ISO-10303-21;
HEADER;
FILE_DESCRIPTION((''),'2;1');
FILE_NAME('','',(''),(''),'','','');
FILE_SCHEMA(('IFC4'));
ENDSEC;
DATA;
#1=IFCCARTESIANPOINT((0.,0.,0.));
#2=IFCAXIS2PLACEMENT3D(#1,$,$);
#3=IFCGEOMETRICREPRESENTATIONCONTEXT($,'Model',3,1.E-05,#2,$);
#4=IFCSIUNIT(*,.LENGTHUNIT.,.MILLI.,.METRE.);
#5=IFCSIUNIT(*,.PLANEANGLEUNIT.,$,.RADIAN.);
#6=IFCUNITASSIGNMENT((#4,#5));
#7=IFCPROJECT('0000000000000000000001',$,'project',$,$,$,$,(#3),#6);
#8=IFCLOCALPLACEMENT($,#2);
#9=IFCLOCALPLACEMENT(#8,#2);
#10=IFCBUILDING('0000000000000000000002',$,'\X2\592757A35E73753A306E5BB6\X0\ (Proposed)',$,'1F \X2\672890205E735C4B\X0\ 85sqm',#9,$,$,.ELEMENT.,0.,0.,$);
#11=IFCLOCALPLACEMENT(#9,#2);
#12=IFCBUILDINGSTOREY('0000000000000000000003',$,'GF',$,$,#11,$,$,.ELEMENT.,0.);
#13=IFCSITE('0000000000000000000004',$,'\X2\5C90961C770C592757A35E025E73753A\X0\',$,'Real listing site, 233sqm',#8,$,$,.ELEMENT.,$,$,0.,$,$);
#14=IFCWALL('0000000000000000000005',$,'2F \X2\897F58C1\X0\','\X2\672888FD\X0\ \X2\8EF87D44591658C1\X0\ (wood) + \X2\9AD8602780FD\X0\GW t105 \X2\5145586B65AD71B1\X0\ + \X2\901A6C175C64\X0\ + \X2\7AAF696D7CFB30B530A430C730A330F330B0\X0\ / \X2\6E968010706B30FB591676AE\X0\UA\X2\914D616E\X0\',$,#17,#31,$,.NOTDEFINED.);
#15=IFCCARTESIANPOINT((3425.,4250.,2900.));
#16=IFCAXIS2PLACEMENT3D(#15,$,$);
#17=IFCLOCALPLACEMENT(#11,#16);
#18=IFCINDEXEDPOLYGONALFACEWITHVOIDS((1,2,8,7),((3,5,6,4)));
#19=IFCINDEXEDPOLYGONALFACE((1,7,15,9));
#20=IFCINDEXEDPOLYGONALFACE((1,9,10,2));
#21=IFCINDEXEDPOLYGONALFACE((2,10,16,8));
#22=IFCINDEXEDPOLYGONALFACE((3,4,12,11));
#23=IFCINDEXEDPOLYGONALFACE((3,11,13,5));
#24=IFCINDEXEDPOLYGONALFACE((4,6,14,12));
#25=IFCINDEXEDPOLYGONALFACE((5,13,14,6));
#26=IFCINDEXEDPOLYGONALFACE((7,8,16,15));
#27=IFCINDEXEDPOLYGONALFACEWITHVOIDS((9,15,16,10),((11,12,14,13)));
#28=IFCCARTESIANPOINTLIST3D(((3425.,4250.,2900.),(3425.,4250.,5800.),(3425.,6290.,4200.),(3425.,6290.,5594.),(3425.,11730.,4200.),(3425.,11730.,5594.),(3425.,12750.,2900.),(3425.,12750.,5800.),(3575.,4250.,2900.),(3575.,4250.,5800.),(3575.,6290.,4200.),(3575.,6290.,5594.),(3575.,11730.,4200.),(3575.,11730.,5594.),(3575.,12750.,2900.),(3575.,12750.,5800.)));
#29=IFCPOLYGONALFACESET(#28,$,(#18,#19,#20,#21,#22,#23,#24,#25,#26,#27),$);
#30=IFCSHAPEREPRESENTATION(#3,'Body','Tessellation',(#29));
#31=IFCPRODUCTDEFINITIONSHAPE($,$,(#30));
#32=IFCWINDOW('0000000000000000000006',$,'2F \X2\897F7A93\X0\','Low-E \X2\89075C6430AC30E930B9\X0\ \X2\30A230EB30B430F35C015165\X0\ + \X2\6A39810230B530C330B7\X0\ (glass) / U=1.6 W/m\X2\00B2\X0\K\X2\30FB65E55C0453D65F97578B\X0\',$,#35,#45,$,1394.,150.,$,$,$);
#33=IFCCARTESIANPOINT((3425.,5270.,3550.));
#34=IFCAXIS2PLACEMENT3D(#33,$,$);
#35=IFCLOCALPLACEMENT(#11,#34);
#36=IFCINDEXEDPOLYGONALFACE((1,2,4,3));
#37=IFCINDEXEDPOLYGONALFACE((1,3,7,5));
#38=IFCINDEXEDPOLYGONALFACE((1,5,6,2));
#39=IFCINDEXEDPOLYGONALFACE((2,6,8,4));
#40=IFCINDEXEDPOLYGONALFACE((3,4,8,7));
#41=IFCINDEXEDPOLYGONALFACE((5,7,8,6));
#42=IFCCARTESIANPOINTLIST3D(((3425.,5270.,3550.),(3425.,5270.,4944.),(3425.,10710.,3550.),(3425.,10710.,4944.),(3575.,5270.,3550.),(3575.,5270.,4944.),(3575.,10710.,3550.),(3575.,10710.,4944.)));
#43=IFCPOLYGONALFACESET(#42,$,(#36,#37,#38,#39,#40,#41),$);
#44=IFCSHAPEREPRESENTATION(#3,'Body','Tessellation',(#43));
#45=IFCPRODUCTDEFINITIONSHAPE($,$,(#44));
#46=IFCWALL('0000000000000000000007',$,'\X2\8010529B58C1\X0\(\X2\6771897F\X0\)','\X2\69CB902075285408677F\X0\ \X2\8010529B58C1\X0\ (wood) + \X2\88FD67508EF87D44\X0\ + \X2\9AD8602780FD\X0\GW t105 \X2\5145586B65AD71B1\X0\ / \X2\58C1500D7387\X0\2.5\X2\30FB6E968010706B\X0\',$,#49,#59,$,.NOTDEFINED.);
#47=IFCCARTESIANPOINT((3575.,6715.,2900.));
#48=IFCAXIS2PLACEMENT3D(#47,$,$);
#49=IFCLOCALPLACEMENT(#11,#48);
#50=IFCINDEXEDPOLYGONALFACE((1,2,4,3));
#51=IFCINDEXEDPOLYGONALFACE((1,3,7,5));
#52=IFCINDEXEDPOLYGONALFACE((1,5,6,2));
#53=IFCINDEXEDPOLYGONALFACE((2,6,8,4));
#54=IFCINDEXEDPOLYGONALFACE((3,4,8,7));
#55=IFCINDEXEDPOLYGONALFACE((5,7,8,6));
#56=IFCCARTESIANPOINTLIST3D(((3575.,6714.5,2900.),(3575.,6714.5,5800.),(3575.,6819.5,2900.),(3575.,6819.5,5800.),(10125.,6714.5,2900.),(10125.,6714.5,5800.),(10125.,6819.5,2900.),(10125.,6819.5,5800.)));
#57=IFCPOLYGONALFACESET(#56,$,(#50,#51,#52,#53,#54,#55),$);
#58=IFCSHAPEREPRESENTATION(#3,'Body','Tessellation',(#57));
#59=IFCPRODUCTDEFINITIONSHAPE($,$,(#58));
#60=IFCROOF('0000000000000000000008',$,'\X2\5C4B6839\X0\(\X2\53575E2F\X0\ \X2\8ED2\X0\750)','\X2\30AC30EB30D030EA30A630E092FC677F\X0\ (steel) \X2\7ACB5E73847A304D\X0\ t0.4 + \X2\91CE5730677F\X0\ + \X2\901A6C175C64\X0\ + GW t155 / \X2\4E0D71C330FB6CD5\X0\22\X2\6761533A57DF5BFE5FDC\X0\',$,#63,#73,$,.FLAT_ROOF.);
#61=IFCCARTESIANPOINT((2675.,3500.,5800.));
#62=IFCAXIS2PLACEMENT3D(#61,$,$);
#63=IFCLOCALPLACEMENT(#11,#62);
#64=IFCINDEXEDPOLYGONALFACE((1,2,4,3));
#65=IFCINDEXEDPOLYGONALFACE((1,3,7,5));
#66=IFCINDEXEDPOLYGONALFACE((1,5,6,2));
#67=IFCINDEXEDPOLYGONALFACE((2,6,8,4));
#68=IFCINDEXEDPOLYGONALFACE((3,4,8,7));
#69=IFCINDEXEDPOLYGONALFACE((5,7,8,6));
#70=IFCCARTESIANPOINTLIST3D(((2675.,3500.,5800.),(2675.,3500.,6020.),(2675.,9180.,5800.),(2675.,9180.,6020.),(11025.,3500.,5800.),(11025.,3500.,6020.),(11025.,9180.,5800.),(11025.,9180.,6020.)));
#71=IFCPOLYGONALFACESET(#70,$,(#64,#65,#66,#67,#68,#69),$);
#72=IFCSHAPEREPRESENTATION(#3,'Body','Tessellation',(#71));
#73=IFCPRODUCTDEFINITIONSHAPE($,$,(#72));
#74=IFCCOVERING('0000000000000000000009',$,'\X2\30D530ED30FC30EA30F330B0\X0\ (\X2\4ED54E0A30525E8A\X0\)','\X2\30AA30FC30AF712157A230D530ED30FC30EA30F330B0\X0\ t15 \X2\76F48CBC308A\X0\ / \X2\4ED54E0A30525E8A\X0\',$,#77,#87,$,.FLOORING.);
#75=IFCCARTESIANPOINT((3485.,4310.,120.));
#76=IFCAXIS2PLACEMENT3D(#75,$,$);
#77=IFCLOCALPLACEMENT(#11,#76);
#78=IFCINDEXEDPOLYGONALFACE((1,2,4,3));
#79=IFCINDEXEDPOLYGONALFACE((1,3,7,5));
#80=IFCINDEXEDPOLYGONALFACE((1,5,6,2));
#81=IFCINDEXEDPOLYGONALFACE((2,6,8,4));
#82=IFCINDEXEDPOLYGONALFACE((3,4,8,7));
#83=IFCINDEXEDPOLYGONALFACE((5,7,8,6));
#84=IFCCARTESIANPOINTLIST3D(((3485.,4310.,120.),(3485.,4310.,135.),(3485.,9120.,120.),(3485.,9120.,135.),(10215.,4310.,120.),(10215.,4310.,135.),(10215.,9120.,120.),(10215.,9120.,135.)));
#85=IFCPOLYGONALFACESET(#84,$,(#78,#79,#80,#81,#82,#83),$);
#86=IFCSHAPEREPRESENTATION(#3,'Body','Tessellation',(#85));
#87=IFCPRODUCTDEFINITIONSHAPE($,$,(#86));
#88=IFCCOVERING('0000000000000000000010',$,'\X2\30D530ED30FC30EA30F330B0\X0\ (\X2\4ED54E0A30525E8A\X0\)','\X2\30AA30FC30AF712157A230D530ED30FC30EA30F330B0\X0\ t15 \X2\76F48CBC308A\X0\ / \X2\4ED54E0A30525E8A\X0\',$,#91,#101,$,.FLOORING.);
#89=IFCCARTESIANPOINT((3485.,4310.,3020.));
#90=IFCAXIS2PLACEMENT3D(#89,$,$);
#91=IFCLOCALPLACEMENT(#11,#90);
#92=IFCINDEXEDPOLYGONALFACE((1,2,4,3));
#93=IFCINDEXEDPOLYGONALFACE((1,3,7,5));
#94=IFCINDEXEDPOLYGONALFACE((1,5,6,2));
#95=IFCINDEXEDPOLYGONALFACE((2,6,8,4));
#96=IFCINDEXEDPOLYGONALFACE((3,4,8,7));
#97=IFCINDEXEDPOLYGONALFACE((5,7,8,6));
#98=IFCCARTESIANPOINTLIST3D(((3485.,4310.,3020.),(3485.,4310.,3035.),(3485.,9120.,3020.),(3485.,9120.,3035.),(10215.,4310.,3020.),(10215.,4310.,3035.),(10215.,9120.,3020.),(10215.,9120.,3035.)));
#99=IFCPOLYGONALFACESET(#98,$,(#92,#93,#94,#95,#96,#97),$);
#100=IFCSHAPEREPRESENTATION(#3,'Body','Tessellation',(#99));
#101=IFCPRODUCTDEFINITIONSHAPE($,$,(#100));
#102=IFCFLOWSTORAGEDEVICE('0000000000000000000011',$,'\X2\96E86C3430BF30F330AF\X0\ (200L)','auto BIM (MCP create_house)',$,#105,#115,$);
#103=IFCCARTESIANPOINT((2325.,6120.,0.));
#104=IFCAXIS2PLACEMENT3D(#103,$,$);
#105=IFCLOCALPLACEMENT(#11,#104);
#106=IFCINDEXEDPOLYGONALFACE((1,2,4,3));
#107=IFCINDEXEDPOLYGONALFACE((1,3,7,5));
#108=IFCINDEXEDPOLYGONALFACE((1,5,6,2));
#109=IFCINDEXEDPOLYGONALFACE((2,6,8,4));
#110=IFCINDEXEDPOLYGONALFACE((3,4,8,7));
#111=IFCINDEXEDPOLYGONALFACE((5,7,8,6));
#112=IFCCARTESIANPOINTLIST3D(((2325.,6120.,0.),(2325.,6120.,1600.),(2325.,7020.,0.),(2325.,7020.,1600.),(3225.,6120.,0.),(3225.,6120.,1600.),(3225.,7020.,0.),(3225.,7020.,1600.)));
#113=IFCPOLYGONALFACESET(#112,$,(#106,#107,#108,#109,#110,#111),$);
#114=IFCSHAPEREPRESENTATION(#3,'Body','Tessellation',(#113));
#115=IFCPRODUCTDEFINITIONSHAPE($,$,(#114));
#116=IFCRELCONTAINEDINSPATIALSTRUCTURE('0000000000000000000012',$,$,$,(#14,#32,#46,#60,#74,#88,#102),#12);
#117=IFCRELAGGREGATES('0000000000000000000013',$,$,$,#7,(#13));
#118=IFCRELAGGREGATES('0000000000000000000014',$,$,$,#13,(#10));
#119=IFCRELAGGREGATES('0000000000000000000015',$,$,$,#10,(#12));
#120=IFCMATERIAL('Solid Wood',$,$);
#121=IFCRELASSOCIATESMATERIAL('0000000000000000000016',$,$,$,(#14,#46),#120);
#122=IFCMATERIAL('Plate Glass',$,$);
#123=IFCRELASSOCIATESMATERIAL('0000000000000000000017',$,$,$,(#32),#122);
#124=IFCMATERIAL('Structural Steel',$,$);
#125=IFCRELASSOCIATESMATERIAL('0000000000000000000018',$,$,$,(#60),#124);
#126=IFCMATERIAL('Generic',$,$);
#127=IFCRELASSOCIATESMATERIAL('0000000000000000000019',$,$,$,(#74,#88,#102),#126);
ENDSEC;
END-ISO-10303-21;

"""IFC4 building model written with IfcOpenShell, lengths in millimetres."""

from ifc_helpers import new_model, si_unit, frame, frame_2d, origin, place, context, project, spatial, rectangle, extrude, material, element, fill, save


model = new_model("IFC4")

# Units and contexts
model_context = context("Model", 3, precision=1e-05, world=origin())
ifc_project = project(units=[si_unit("LENGTHUNIT", "METRE", prefix="MILLI"), si_unit("PLANEANGLEUNIT", "RADIAN")], contexts=[model_context])

# Site, building, storey
site_placement = place(None, origin())
site = spatial("IfcSite", under=ifc_project, at=site_placement, Name="岐阜県大垣市平町", ObjectType="Real listing site, 233sqm", CompositionType="ELEMENT", RefElevation=0.0)
building_placement = place(site_placement, origin())
building = spatial("IfcBuilding", under=site, at=building_placement, Name="大垣平町の家 (Proposed)", ObjectType="1F 木造平屋 85sqm", CompositionType="ELEMENT", ElevationOfRefHeight=0.0, ElevationOfTerrain=0.0)
storey_placement = place(building_placement, origin())
storey = spatial("IfcBuildingStorey", under=building, at=storey_placement, Name="GF", CompositionType="ELEMENT", Elevation=0.0)

# Shared definitions
ifc_material_1 = material(Name="Solid Wood")
ifc_material_2 = material(Name="Generic")

# Shared definitions
ifc_material_3 = material(Name="Plate Glass")

# Wall, opening, window
wall_1_placement = place(storey_placement, frame((3425.0, 4250.0, 2900.0)))
wall_1 = element("IfcWall", 1, at=wall_1_placement, inside=storey, material=ifc_material_1, Name="2F 西壁", Description="木製 軸組外壁 (wood) + 高性能GW t105 充填断熱 + 通気層 + 窯業系サイディング / 準耐火・外皮UA配慮", PredefinedType="NOTDEFINED", context=model_context, shape_type="SweptSolid", body=[
    extrude(rectangle(XDim=150.0, YDim=8500.0, at=frame_2d((75.0, 4250.0))), frame((3425.0, 4250.0, 2900.0)), (0.0, 0.0, 1.0), 2900.0),
])
opening_1_placement = place(storey_placement, frame((3425.0, 5270.0, 3550.0)))
opening_1 = element("IfcOpeningElement", 2, at=opening_1_placement, cuts=wall_1, PredefinedType="NOTDEFINED", context=model_context, shape_type="SweptSolid", body=[
    extrude(rectangle(XDim=150.0, YDim=5440.0, at=frame_2d((75.0, 2720.0))), frame((3425.0, 5270.0, 3550.0)), (0.0, 0.0, 1.0), 1394.0),
])
window_1_placement = place(storey_placement, frame((3425.0, 5270.0, 3550.0)))
window_1 = element("IfcWindow", 3, at=window_1_placement, inside=storey, material=ifc_material_3, Name="2F 西窓", Description="Low-E 複層ガラス アルゴン封入 + 樹脂サッシ (glass) / U=1.6 W/m²K・日射取得型", OverallHeight=1394.0, OverallWidth=150.0, context=model_context, shape_type="SweptSolid", body=[
    extrude(rectangle(XDim=150.0, YDim=5440.0, at=frame_2d((75.0, 2720.0))), frame((3425.0, 5270.0, 3550.0)), (0.0, 0.0, 1.0), 1394.0),
])
fill(opening_1, window_1)

# Wall
wall_2_placement = place(storey_placement, frame((3575.0, 6715.0, 2900.0)))
element("IfcWall", 4, at=wall_2_placement, inside=storey, material=ifc_material_1, Name="耐力壁(東西)", Description="構造用合板 耐力壁 (wood) + 製材軸組 + 高性能GW t105 充填断熱 / 壁倍率2.5・準耐火", PredefinedType="NOTDEFINED", context=model_context, shape_type="SweptSolid", body=[
    extrude(rectangle(XDim=6550.0, YDim=105.0, at=frame_2d((3275.0, 52.0))), frame((3575.0, 6715.0, 2900.0)), (0.0, 0.0, 1.0), 2900.0),
])

# Roof
ifc_material_4 = material(Name="Structural Steel")
for number, where, name in (
    (5, (2675.0, 3500.0, 5800.0), "屋根(南帯 軒750)"),
):
    element("IfcRoof", number, at=place(storey_placement, frame(where)), inside=storey, material=ifc_material_4, Name=name, Description="ガルバリウム鋼板 (steel) 立平葺き t0.4 + 野地板 + 通気層 + GW t155 / 不燃・法22条区域対応", PredefinedType="FLAT_ROOF", context=model_context, shape_type="SweptSolid", body=[
        extrude(rectangle(XDim=8350.0, YDim=5680.0, at=frame_2d((4175.0, 2840.0))), frame((2675.0, 3500.0, 5800.0)), (0.0, 0.0, 1.0), 220.0),
    ])

# Coverings
covering_1_placement = place(storey_placement, frame((3485.0, 4310.0, 120.0)))
element("IfcCovering", 6, at=covering_1_placement, inside=storey, material=ifc_material_2, Name="フローリング (仕上げ床)", Description="オーク無垢フローリング t15 直貼り / 仕上げ床", PredefinedType="FLOORING", context=model_context, shape_type="SweptSolid", body=[
    extrude(rectangle(XDim=6730.0, YDim=4810.0, at=frame_2d((3365.0, 2405.0))), frame((3485.0, 4310.0, 120.0)), (0.0, 0.0, 1.0), 15.0),
])
covering_2_placement = place(storey_placement, frame((3485.0, 4310.0, 3020.0)))
element("IfcCovering", 7, at=covering_2_placement, inside=storey, material=ifc_material_2, Name="フローリング (仕上げ床)", Description="オーク無垢フローリング t15 直貼り / 仕上げ床", PredefinedType="FLOORING", context=model_context, shape_type="SweptSolid", body=[
    extrude(rectangle(XDim=6730.0, YDim=4810.0, at=frame_2d((3365.0, 2405.0))), frame((3485.0, 4310.0, 3020.0)), (0.0, 0.0, 1.0), 15.0),
])

# Flow storage device
flow_storage_device_placement = place(storey_placement, frame((2325.0, 6120.0, 0.0)))
element("IfcFlowStorageDevice", 8, at=flow_storage_device_placement, inside=storey, material=ifc_material_2, Name="雨水タンク (200L)", Description="auto BIM (MCP create_house)", context=model_context, shape_type="SweptSolid", body=[
    extrude(rectangle(XDim=900.0, YDim=900.0, at=frame_2d((450.0, 450.0))), frame((2325.0, 6120.0, 0.0)), (0.0, 0.0, 1.0), 1600.0),
])

save(model, "model.ifc")
